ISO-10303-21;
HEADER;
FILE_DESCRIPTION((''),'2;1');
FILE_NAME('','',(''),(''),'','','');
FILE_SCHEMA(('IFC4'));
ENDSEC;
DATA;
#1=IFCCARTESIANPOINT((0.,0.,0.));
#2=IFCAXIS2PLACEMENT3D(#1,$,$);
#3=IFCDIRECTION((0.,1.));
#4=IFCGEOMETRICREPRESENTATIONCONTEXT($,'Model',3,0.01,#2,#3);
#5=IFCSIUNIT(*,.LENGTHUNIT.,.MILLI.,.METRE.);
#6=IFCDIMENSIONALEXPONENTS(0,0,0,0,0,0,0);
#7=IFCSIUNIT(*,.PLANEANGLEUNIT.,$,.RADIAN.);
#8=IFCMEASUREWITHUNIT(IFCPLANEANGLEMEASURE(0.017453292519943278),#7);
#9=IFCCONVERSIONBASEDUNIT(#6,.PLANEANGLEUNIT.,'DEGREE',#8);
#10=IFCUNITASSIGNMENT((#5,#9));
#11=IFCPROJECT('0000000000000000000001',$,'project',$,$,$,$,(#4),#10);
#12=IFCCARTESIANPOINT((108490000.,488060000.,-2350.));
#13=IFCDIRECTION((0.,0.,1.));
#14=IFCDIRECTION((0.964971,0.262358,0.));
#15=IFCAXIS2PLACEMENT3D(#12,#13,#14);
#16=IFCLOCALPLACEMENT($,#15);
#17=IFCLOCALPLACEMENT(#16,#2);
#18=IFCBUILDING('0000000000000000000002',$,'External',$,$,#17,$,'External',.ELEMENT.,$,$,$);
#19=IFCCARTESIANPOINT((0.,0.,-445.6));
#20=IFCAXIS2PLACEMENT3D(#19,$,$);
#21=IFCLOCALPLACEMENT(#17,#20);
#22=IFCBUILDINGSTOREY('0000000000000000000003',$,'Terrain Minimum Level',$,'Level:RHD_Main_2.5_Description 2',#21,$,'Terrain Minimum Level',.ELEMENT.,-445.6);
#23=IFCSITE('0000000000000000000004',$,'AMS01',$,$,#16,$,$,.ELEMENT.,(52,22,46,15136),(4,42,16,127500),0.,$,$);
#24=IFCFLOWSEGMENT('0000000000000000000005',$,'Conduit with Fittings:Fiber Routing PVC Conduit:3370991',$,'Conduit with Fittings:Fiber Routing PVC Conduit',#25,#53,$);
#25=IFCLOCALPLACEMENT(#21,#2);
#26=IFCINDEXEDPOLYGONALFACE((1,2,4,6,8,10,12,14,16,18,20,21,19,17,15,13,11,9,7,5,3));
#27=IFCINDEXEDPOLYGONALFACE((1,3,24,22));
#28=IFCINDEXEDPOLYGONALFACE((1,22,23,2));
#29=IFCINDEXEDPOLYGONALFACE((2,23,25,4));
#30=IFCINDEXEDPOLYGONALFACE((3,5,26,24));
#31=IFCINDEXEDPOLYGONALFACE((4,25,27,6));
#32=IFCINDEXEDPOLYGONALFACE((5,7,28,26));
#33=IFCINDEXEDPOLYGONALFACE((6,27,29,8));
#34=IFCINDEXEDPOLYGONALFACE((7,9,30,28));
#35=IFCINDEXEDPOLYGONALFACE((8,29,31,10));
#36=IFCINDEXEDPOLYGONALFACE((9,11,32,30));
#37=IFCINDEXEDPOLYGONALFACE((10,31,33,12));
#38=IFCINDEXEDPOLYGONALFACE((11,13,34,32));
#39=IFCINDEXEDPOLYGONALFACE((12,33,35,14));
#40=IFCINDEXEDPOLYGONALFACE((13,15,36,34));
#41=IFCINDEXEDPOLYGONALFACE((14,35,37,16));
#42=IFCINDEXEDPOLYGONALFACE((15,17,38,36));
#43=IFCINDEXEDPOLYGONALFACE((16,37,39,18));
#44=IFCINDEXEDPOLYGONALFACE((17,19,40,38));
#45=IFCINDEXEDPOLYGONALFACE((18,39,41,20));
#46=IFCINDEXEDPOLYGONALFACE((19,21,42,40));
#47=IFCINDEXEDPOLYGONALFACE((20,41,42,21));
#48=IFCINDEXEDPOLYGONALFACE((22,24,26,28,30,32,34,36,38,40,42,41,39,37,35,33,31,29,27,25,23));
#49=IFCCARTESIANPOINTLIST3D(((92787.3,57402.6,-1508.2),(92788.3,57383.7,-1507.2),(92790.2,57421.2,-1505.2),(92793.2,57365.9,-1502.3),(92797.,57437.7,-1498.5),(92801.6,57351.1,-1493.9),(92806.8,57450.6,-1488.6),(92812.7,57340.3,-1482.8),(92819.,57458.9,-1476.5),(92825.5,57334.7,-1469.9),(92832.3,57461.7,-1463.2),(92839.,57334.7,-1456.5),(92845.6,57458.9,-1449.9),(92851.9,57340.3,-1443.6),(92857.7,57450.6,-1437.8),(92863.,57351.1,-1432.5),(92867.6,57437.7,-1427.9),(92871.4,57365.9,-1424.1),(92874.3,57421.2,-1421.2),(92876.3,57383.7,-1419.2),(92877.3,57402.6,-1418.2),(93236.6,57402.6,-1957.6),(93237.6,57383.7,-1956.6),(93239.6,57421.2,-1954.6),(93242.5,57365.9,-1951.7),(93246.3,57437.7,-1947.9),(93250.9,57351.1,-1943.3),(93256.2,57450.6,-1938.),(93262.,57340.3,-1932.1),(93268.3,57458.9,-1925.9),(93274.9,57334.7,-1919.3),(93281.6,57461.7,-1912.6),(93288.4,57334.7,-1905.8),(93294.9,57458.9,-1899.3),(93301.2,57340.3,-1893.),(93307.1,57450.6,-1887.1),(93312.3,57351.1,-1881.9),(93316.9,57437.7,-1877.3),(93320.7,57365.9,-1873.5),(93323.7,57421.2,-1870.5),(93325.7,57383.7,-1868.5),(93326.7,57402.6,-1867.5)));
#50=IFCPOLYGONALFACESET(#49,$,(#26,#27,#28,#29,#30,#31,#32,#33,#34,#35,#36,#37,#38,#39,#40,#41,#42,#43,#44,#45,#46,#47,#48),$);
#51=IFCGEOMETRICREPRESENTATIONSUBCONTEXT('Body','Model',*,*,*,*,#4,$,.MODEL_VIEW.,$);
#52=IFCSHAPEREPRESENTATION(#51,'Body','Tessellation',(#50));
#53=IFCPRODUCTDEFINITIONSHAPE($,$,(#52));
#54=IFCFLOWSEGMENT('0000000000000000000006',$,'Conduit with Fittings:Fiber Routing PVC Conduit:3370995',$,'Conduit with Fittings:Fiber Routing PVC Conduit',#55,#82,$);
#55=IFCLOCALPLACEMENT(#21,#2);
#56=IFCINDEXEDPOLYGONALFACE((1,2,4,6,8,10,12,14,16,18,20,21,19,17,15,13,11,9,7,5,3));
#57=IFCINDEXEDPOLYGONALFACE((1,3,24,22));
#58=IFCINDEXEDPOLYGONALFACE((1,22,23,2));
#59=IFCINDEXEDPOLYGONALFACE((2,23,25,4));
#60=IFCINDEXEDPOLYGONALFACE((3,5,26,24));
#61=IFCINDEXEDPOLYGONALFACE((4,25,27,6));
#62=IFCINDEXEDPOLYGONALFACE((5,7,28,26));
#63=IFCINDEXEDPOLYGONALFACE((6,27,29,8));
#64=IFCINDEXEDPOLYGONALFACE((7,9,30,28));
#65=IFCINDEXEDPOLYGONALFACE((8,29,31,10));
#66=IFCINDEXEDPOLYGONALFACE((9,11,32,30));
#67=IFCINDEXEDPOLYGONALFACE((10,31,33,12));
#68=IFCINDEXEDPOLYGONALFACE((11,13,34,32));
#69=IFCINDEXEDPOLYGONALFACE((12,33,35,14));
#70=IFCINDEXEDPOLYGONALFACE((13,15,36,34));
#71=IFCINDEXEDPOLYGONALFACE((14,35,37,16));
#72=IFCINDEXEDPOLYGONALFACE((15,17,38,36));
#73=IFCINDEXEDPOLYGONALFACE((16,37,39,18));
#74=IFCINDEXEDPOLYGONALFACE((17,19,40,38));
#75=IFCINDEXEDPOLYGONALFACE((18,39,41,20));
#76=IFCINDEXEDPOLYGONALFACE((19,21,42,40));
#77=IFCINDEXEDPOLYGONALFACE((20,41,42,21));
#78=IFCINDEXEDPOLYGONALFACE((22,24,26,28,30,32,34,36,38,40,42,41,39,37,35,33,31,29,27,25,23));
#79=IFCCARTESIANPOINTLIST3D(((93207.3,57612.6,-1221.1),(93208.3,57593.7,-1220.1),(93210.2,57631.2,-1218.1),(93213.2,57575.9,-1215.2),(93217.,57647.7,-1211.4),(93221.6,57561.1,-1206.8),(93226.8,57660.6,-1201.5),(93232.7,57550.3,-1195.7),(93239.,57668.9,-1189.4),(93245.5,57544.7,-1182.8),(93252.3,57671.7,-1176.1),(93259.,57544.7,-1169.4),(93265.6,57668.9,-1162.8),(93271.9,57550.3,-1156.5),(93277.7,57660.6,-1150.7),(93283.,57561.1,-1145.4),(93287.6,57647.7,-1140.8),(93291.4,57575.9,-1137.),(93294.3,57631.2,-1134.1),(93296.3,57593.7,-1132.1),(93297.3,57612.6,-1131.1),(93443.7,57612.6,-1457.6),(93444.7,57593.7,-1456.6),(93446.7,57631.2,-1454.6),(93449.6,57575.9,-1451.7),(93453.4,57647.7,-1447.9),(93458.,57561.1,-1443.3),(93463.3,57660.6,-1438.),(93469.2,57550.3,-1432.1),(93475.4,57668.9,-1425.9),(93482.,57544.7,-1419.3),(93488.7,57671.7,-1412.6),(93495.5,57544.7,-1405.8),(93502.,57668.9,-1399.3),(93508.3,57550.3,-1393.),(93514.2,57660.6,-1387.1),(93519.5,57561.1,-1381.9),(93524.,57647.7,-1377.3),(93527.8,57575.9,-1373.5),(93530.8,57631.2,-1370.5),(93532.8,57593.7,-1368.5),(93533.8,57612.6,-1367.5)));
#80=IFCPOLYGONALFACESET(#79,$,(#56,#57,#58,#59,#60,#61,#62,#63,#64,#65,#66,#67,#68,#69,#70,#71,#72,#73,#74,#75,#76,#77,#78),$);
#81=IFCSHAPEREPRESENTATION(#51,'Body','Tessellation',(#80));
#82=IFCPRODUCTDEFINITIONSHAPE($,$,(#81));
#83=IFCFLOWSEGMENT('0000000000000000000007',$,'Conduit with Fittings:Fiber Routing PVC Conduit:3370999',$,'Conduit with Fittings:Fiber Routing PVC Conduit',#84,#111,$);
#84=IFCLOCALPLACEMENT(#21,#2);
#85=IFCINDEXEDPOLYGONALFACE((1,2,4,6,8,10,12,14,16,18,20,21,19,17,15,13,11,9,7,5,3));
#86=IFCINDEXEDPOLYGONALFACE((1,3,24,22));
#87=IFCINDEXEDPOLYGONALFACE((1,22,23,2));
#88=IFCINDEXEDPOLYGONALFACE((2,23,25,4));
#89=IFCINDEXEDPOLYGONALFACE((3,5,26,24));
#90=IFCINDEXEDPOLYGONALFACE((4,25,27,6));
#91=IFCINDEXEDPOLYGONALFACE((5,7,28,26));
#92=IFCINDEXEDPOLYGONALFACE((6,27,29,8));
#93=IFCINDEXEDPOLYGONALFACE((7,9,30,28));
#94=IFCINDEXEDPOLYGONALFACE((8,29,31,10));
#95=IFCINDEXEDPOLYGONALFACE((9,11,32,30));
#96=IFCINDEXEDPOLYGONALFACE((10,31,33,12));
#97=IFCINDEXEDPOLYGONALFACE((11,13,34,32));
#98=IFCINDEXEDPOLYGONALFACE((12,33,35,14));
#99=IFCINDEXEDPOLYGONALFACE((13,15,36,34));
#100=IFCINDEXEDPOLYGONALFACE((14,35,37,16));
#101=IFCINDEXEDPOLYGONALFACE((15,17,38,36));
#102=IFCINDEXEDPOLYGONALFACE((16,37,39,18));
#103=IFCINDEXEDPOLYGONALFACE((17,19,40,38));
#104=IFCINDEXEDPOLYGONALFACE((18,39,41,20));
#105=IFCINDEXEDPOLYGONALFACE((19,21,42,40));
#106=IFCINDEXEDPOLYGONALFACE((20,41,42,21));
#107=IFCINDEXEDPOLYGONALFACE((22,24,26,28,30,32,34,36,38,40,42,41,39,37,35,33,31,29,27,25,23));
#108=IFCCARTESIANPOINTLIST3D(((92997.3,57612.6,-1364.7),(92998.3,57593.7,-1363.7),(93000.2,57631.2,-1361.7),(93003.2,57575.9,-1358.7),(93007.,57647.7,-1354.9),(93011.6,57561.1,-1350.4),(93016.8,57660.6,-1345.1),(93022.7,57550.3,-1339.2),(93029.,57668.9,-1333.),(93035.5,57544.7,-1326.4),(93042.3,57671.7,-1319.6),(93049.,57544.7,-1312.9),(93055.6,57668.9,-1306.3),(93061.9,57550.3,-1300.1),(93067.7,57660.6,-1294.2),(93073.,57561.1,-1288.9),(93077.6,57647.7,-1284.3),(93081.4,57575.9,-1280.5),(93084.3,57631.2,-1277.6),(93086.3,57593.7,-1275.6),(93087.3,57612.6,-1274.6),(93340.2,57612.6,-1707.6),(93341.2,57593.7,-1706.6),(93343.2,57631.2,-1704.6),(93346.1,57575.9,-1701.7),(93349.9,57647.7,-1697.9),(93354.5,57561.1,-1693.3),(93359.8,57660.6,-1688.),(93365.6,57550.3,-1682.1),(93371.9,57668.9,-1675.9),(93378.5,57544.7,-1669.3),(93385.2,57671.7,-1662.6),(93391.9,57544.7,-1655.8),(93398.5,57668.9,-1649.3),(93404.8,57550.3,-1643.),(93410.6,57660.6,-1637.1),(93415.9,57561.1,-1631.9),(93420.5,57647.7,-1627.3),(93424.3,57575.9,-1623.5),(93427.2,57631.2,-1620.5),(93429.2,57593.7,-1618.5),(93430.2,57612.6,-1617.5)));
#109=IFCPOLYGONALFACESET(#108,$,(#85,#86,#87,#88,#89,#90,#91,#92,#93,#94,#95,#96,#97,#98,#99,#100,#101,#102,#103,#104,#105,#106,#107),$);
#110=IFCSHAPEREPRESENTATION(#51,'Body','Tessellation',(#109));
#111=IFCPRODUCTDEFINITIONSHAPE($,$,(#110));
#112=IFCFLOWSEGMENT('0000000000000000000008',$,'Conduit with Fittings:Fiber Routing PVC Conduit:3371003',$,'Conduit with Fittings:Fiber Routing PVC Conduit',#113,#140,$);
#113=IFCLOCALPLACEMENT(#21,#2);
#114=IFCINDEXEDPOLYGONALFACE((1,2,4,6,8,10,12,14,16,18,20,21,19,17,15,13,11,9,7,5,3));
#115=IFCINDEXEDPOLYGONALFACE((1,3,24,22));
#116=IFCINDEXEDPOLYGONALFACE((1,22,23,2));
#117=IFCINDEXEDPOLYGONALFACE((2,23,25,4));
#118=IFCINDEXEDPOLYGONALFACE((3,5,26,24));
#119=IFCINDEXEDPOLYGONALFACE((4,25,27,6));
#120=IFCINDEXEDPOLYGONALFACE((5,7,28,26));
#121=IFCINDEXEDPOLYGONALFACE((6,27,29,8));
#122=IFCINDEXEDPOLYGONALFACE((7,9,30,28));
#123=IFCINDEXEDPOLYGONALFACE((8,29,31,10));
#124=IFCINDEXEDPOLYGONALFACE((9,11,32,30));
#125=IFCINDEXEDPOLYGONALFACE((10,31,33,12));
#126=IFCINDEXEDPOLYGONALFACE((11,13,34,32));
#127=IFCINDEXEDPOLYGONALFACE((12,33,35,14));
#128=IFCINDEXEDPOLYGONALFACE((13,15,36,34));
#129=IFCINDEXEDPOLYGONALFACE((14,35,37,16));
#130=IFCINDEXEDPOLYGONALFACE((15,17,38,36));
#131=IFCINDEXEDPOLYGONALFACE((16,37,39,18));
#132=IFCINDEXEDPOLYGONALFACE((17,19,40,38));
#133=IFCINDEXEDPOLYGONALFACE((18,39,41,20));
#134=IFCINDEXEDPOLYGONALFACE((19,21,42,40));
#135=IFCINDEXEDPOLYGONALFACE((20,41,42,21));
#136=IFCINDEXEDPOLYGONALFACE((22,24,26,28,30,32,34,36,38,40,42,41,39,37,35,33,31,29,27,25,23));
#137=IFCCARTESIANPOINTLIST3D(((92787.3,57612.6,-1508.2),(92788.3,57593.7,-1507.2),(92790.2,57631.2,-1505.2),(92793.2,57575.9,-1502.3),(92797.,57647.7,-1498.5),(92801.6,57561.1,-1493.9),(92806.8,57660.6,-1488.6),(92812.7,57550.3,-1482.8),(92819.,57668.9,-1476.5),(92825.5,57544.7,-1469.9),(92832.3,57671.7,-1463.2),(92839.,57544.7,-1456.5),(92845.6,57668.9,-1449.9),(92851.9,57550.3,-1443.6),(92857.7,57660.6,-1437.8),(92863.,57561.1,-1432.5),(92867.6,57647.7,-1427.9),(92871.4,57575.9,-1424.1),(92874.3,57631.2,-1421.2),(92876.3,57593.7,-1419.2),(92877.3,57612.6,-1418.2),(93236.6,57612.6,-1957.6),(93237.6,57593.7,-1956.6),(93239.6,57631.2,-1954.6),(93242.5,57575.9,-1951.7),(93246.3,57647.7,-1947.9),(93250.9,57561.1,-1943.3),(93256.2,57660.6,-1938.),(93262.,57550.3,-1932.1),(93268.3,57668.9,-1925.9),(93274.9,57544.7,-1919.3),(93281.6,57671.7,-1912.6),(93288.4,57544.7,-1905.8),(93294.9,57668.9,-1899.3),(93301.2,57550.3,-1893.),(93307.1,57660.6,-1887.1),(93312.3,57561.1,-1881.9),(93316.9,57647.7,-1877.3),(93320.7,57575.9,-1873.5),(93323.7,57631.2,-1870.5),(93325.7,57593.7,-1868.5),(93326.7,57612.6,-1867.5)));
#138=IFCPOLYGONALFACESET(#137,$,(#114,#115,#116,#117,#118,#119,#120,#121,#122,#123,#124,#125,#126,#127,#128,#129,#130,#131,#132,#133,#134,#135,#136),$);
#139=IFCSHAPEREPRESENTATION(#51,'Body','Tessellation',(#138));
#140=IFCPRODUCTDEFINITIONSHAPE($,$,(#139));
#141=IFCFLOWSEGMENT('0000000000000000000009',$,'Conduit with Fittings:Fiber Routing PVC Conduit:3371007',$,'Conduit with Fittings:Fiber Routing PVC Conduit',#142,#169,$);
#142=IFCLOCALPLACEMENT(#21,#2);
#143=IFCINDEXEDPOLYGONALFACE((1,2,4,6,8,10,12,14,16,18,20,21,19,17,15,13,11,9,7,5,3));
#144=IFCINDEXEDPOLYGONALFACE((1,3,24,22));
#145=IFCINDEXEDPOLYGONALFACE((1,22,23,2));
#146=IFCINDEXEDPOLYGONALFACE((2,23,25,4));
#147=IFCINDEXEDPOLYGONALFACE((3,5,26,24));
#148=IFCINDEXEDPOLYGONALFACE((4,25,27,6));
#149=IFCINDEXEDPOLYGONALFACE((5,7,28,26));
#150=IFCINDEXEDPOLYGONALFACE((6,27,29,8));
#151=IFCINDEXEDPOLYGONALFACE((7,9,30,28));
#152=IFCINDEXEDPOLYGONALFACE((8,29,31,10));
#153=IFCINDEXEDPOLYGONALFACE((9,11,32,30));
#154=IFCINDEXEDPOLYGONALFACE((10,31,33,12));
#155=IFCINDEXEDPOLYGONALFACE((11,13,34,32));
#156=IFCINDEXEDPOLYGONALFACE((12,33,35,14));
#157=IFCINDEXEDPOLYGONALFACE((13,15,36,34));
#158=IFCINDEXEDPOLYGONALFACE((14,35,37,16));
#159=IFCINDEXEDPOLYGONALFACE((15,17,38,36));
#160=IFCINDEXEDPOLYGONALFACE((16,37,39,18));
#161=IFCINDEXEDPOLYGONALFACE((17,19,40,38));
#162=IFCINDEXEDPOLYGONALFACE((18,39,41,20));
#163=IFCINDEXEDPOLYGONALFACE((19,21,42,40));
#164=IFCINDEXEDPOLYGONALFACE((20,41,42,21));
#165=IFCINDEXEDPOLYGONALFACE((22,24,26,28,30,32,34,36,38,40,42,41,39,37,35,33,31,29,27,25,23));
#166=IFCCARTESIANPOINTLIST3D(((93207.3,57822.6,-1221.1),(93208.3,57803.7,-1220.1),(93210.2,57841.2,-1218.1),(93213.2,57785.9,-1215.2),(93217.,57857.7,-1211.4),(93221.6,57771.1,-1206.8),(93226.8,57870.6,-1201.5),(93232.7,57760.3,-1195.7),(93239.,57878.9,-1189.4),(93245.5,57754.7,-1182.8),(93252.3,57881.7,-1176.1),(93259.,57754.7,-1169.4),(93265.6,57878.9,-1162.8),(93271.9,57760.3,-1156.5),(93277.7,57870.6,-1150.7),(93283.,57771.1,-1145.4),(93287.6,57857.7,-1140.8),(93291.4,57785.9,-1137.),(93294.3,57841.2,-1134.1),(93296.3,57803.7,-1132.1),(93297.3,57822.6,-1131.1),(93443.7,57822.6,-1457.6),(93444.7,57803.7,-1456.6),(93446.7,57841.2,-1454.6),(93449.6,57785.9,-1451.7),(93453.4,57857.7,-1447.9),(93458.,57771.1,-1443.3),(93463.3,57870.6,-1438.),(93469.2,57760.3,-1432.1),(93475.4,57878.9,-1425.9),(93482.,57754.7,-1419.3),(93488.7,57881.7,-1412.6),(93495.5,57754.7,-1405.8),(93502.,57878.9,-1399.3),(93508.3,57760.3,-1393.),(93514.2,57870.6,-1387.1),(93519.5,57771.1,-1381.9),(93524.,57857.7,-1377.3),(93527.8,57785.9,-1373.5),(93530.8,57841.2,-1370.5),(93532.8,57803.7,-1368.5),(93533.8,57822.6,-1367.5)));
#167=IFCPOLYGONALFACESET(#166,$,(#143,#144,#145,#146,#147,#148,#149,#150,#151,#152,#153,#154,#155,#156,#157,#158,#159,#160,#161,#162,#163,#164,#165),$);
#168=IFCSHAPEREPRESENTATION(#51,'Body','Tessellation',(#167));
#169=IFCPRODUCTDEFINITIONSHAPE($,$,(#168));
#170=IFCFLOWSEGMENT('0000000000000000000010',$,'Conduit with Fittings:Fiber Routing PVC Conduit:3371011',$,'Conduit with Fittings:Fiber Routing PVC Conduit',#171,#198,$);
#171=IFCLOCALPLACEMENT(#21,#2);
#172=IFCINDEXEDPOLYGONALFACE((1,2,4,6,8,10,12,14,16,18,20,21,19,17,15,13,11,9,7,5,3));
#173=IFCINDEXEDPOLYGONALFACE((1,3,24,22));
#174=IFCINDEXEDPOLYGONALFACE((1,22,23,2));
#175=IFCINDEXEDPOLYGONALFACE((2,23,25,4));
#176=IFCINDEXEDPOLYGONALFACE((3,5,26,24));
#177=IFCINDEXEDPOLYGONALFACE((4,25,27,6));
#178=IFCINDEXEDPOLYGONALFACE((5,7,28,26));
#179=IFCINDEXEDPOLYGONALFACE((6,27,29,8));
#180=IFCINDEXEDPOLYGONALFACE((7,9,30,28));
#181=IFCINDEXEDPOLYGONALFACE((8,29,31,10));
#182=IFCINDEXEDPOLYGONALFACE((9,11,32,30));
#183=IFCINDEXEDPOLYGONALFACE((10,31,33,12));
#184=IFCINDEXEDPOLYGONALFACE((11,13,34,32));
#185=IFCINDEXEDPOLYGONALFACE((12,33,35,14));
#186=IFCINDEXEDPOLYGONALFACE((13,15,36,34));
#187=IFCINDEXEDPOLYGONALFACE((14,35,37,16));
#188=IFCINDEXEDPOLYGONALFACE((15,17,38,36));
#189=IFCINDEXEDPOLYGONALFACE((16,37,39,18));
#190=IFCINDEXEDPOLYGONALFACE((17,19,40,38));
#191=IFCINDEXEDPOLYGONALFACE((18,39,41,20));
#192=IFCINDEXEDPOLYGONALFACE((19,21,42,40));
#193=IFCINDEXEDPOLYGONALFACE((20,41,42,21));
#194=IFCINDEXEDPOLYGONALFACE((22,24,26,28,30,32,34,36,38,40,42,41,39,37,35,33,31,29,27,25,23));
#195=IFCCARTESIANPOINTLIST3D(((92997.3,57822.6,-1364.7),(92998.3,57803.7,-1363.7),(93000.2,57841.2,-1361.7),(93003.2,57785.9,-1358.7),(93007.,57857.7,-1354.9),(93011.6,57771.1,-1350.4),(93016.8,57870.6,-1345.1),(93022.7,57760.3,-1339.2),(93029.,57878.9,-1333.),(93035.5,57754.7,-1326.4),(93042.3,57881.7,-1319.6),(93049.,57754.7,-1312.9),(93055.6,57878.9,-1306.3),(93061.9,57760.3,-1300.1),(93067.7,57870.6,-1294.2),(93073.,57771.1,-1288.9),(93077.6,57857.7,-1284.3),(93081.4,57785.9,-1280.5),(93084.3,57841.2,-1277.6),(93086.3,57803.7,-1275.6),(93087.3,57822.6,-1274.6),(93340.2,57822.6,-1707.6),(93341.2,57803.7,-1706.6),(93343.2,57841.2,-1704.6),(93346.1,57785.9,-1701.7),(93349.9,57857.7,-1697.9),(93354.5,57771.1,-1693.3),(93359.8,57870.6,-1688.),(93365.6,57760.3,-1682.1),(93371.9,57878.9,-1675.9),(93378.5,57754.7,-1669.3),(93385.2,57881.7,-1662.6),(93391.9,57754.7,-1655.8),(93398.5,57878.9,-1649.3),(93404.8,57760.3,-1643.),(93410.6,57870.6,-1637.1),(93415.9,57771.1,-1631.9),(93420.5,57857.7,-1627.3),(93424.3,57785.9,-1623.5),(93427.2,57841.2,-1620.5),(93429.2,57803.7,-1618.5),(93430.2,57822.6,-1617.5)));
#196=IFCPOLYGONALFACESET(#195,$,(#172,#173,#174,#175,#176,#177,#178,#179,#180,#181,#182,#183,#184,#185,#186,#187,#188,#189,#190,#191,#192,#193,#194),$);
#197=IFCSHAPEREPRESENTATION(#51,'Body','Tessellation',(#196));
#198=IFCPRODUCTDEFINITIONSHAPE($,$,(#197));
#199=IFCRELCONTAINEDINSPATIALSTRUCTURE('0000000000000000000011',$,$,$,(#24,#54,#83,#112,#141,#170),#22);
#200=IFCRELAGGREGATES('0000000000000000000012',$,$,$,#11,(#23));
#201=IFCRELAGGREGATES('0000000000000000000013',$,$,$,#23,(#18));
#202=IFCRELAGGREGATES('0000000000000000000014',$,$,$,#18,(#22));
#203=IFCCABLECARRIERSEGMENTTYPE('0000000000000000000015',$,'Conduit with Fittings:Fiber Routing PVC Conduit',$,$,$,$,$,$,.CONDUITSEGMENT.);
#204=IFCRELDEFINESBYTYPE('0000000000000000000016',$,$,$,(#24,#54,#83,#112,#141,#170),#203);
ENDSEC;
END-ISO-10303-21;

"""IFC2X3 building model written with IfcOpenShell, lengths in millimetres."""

from ifc_helpers import new_model, entity, si_unit, converted_unit, direction, frame, frame_2d, origin, origin_2d_with_axis, place, context, subcontext, project, spatial, circle, extrude, type_object, element, save


model = new_model("IFC2X3")

# Units and contexts
model_context = context("Model", 3, precision=0.01, world=origin(), true_north=direction((0.0, 1.0)))
body_context = subcontext(model_context, "Body", "Model", "MODEL_VIEW")
ifc_project = project(units=[si_unit("LENGTHUNIT", "METRE", prefix="MILLI"), converted_unit("PLANEANGLEUNIT", "DEGREE", entity("IfcPlaneAngleMeasure", 0.017453292519943278), si_unit("PLANEANGLEUNIT", "RADIAN"), dimensions=[0, 0, 0, 0, 0, 0, 0])], contexts=[model_context])

# Site, building, storey
site_placement = place(None, frame((108490000.0, 488060000.0, -2350.0), z_axis=(0.0, 0.0, 1.0), x_axis=(0.964971, 0.262358, 0.0)))
site = spatial("IfcSite", under=ifc_project, at=site_placement, Name="AMS01", CompositionType="ELEMENT", RefLatitude=(52, 22, 46, 15136), RefLongitude=(4, 42, 16, 127500), RefElevation=0.0)
building_placement = place(site_placement, origin())
building = spatial("IfcBuilding", under=site, at=building_placement, Name="External", LongName="External", CompositionType="ELEMENT")
storey_placement = place(building_placement, frame((0.0, 0.0, -445.6)))
storey = spatial("IfcBuildingStorey", under=building, at=storey_placement, Name="Terrain Minimum Level", ObjectType="Level:RHD_Main_2.5_Description 2", LongName="Terrain Minimum Level", CompositionType="ELEMENT", Elevation=-445.6)

# Flow segments
cable_carrier_segment_type = type_object("IfcCableCarrierSegmentType", Name="Conduit with Fittings:Fiber Routing PVC Conduit", PredefinedType="CONDUITSEGMENT")
flow_segment_1_placement = place(storey_placement, origin())
element("IfcFlowSegment", 1, at=flow_segment_1_placement, inside=storey, type_object=cable_carrier_segment_type, Name="Conduit with Fittings:Fiber Routing PVC Conduit:3370991", ObjectType="Conduit with Fittings:Fiber Routing PVC Conduit", context=body_context, shape_type="SweptSolid", body=[
    extrude(circle(Radius=63.9, at=origin_2d_with_axis()), frame((93281.6, 57397.9, -1912.6), z_axis=(-0.707107, 0.0, 0.707107), x_axis=(0.0, 1.0, 0.0)), (0.0, 0.0, 1.0), 635.5),
])
flow_segment_2_placement = place(storey_placement, origin())
element("IfcFlowSegment", 2, at=flow_segment_2_placement, inside=storey, type_object=cable_carrier_segment_type, Name="Conduit with Fittings:Fiber Routing PVC Conduit:3370995", ObjectType="Conduit with Fittings:Fiber Routing PVC Conduit", context=body_context, shape_type="SweptSolid", body=[
    extrude(circle(Radius=63.9, at=frame_2d((0.0, 0.0), x_axis=(1.0, 0.0))), frame((93252.3, 57607.9, -1176.1), z_axis=(0.707107, 0.0, -0.707107), x_axis=(0.0, 1.0, 0.0)), (0.0, 0.0, 1.0), 334.4),
])
flow_segment_3_placement = place(storey_placement, origin())
element("IfcFlowSegment", 3, at=flow_segment_3_placement, inside=storey, type_object=cable_carrier_segment_type, Name="Conduit with Fittings:Fiber Routing PVC Conduit:3370999", ObjectType="Conduit with Fittings:Fiber Routing PVC Conduit", context=body_context, shape_type="SweptSolid", body=[
    extrude(circle(Radius=63.9, at=frame_2d((0.0, 0.0), x_axis=(1.0, 0.0))), frame((93385.2, 57607.9, -1662.6), z_axis=(-0.707107, 0.0, 0.707107), x_axis=(0.0, 1.0, 0.0)), (0.0, 0.0, 1.0), 485.0),
])
flow_segment_4_placement = place(storey_placement, origin())
element("IfcFlowSegment", 4, at=flow_segment_4_placement, inside=storey, type_object=cable_carrier_segment_type, Name="Conduit with Fittings:Fiber Routing PVC Conduit:3371003", ObjectType="Conduit with Fittings:Fiber Routing PVC Conduit", context=body_context, shape_type="SweptSolid", body=[
    extrude(circle(Radius=63.9, at=frame_2d((0.0, 0.0), x_axis=(1.0, 0.0))), frame((93281.6, 57607.9, -1912.6), z_axis=(-0.707107, 0.0, 0.707107), x_axis=(0.0, 1.0, 0.0)), (0.0, 0.0, 1.0), 635.5),
])
flow_segment_5_placement = place(storey_placement, origin())
element("IfcFlowSegment", 5, at=flow_segment_5_placement, inside=storey, type_object=cable_carrier_segment_type, Name="Conduit with Fittings:Fiber Routing PVC Conduit:3371007", ObjectType="Conduit with Fittings:Fiber Routing PVC Conduit", context=body_context, shape_type="SweptSolid", body=[
    extrude(circle(Radius=63.9, at=frame_2d((0.0, 0.0), x_axis=(1.0, 0.0))), frame((93488.7, 57817.9, -1412.6), z_axis=(-0.707107, 0.0, 0.707107), x_axis=(0.0, 1.0, 0.0)), (0.0, 0.0, 1.0), 334.4),
])
flow_segment_6_placement = place(storey_placement, origin())
element("IfcFlowSegment", 6, at=flow_segment_6_placement, inside=storey, type_object=cable_carrier_segment_type, Name="Conduit with Fittings:Fiber Routing PVC Conduit:3371011", ObjectType="Conduit with Fittings:Fiber Routing PVC Conduit", context=body_context, shape_type="SweptSolid", body=[
    extrude(circle(Radius=63.9, at=origin_2d_with_axis()), frame((93385.2, 57817.9, -1662.6), z_axis=(-0.707107, 0.0, 0.707107), x_axis=(0.0, 1.0, 0.0)), (0.0, 0.0, 1.0), 485.0),
])

save(model, "model.ifc")
